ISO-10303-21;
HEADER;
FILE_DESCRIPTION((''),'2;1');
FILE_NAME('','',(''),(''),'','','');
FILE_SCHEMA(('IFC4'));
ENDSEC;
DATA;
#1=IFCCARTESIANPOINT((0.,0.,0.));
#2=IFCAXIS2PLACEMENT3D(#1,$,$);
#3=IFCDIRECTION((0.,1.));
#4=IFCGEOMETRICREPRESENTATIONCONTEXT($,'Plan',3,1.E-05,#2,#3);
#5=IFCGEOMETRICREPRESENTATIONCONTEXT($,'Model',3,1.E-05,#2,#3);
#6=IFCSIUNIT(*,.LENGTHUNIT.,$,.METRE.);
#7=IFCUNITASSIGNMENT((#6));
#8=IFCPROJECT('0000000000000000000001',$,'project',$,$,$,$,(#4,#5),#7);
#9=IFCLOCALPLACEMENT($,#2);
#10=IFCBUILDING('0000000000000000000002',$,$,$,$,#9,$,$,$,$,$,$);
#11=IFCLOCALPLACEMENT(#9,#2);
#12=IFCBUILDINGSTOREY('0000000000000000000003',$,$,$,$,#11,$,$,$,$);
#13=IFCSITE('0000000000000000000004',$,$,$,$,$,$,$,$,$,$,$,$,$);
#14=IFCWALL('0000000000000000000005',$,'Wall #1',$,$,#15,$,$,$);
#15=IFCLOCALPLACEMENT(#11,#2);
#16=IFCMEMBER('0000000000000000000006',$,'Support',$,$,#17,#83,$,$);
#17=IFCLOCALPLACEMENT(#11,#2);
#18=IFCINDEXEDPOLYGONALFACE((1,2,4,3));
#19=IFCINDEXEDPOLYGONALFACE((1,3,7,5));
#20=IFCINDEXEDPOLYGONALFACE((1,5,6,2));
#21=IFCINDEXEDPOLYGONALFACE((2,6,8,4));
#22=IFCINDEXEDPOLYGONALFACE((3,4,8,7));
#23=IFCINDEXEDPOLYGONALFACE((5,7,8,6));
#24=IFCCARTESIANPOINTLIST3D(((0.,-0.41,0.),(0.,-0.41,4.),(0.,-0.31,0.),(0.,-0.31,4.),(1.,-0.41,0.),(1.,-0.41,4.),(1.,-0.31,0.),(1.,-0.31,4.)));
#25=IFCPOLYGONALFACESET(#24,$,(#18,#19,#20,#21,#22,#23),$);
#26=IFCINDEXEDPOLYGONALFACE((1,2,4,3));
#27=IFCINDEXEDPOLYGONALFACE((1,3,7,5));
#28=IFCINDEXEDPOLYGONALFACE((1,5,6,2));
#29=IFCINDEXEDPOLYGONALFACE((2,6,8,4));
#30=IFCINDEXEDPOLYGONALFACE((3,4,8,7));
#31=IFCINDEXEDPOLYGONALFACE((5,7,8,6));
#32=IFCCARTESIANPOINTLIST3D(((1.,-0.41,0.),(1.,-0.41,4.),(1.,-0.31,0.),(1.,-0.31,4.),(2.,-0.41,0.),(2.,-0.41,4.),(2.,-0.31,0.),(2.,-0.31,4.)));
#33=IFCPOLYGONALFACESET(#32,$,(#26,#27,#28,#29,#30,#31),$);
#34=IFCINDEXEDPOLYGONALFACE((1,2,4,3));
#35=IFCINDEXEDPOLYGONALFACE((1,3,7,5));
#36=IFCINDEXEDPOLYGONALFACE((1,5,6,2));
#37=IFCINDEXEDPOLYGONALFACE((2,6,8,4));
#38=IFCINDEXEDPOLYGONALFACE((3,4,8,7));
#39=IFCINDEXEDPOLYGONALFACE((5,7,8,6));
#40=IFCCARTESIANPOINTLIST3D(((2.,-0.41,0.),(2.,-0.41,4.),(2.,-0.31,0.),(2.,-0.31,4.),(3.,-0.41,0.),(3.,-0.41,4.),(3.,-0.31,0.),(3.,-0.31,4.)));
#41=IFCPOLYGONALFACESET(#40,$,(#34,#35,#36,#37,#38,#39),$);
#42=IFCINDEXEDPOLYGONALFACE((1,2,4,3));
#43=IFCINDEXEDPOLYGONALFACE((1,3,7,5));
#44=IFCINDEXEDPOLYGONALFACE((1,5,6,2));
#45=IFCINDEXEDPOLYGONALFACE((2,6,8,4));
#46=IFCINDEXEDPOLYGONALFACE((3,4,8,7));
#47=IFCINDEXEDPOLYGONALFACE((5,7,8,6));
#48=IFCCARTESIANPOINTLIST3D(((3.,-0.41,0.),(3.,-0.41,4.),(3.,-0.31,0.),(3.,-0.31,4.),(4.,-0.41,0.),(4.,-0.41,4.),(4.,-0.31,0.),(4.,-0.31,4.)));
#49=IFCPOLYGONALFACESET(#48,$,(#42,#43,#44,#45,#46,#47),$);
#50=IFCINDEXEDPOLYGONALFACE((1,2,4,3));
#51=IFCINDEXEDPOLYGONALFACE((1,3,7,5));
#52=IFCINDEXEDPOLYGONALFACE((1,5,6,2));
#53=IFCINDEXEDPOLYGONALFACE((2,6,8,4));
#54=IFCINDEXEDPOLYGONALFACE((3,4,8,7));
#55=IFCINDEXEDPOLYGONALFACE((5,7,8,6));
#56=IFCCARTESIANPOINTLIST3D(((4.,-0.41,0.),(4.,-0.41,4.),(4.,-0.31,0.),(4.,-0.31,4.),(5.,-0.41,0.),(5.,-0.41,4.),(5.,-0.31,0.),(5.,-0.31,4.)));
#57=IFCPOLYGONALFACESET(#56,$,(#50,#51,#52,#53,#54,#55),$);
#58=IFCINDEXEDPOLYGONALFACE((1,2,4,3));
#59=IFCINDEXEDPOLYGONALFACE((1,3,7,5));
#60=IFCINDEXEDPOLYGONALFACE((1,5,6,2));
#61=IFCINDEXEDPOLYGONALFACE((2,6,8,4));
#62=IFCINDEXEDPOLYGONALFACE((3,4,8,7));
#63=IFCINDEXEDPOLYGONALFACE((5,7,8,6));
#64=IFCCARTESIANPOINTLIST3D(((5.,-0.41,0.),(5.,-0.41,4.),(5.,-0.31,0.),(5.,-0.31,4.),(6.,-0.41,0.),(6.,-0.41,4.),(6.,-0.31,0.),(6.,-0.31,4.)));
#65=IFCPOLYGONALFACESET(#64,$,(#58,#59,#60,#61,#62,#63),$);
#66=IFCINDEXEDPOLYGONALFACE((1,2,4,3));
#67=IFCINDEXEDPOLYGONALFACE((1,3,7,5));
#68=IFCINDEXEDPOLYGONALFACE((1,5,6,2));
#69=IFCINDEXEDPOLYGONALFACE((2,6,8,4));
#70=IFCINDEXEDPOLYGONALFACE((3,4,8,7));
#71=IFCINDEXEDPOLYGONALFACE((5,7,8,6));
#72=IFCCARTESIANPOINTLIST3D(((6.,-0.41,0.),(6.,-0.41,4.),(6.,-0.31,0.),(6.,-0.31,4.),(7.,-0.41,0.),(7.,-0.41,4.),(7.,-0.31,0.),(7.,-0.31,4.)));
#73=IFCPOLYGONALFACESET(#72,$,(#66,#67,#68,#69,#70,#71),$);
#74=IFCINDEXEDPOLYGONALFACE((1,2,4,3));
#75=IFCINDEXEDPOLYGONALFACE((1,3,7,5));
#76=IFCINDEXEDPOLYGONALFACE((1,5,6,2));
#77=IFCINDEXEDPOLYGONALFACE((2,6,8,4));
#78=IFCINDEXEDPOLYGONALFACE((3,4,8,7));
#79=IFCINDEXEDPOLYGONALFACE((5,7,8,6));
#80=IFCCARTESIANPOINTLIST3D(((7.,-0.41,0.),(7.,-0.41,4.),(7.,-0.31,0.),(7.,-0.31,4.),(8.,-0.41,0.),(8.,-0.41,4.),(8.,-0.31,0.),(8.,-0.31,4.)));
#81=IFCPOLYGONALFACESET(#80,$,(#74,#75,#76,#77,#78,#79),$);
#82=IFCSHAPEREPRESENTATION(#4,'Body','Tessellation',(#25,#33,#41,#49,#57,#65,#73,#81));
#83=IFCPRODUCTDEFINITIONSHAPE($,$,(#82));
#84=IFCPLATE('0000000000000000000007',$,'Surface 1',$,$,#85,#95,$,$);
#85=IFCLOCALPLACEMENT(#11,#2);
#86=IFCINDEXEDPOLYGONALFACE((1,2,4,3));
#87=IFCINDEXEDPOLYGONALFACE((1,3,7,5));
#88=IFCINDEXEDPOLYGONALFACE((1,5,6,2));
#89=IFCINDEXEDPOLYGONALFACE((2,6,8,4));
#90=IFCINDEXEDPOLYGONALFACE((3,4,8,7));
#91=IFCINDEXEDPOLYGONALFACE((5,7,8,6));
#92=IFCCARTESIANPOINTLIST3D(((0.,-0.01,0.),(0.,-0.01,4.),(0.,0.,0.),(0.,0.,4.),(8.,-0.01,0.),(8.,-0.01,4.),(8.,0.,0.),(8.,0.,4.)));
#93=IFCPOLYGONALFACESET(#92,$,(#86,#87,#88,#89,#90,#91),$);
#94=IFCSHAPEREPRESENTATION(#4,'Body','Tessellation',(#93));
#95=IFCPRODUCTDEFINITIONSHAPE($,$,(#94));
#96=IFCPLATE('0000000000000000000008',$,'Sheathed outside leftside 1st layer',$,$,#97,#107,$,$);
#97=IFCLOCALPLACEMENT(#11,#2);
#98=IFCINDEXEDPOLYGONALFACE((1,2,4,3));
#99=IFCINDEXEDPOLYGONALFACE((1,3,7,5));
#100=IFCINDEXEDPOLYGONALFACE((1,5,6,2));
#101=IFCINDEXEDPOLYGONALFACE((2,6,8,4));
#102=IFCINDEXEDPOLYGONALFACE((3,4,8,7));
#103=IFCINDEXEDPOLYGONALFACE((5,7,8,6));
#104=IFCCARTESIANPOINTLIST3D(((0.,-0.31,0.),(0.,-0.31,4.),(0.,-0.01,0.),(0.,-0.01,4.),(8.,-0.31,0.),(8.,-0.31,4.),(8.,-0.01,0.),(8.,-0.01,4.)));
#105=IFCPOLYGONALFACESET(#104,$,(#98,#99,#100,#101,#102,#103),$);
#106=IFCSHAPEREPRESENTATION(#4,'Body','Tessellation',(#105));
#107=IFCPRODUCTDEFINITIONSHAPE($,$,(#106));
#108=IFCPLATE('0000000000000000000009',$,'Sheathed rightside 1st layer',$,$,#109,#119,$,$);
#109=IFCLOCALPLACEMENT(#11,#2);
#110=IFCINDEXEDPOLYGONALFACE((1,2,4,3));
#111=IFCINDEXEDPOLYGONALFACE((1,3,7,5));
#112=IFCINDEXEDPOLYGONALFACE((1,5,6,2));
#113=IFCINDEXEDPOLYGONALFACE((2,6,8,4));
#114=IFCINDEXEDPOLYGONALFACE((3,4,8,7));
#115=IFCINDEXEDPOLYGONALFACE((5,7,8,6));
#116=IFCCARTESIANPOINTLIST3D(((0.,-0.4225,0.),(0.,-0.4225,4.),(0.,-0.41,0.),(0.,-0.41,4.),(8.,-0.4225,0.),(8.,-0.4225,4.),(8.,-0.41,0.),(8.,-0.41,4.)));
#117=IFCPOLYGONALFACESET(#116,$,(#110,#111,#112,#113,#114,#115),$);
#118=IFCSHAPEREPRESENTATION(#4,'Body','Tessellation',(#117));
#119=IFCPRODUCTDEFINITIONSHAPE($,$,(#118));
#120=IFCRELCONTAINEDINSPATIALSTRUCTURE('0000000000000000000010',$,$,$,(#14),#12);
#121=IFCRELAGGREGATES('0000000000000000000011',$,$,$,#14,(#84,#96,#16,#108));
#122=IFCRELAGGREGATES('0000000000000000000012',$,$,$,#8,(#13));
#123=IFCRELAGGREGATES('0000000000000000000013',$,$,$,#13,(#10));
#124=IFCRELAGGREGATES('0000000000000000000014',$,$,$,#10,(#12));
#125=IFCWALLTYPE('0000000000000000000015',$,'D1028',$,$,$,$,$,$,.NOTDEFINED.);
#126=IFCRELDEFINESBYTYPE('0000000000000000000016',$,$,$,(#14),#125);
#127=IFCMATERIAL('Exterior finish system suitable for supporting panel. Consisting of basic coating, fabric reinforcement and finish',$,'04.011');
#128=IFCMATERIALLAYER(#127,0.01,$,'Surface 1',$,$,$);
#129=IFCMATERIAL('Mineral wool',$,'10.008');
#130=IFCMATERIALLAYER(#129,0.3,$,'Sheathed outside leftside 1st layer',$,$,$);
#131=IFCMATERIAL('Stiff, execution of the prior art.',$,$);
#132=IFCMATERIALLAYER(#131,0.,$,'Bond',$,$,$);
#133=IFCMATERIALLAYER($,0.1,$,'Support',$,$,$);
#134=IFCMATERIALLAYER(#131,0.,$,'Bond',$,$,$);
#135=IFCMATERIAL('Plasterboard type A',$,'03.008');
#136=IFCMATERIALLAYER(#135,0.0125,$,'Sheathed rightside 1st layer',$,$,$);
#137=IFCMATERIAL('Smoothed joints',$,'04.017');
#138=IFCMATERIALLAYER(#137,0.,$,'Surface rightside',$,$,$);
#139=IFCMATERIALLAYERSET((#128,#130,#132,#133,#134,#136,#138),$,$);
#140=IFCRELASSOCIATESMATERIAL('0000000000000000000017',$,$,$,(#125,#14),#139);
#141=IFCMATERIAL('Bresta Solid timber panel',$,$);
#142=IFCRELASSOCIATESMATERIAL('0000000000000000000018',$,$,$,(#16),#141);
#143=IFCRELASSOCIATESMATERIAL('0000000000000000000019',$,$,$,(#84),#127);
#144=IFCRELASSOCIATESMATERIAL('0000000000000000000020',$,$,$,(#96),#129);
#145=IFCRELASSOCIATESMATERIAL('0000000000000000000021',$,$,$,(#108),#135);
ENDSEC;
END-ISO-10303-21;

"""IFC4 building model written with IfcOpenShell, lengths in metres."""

from ifc_helpers import new_model, si_unit, direction, frame, frame_2d, origin, origin_with_axes, place, context, project, spatial, rectangle, extrude, material, layer, layer_set, type_object, element, aggregate, save


model = new_model("IFC4")

# Units and contexts
plan_context = context("Plan", 3, precision=1e-05, world=origin(), true_north=direction((0.0, 1.0)))
model_context = context("Model", 3, precision=1e-05, world=origin(), true_north=direction((0.0, 1.0)))
ifc_project = project(units=[si_unit("LENGTHUNIT", "METRE")], contexts=[plan_context, model_context])

# Site, building, storey
site = spatial("IfcSite", under=ifc_project)
building_placement = place(None, origin())
building = spatial("IfcBuilding", under=site, at=building_placement)
storey_placement = place(building_placement, origin())
storey = spatial("IfcBuildingStorey", under=building, at=storey_placement)

# Wall, member, plates
ifc_material_1 = material(Name="Exterior finish system suitable for supporting panel. Consisting of basic coating, fabric reinforcement and finish", Category="04.011")
ifc_layer_1 = layer(ifc_material_1, 0.01, Name="Surface 1")
ifc_material_2 = material(Name="Mineral wool", Category="10.008")
ifc_layer_2 = layer(ifc_material_2, 0.3, Name="Sheathed outside leftside 1st layer")
ifc_material_3 = material(Name="Stiff, execution of the prior art.")
ifc_layer_3 = layer(ifc_material_3, 0.0, Name="Bond")
ifc_layer_4 = layer(None, 0.1, Name="Support")
ifc_layer_5 = layer(ifc_material_3, 0.0, Name="Bond")
ifc_material_4 = material(Name="Plasterboard type A", Category="03.008")
ifc_layer_6 = layer(ifc_material_4, 0.0125, Name="Sheathed rightside 1st layer")
ifc_material_5 = material(Name="Smoothed joints", Category="04.017")
ifc_layer_7 = layer(ifc_material_5, 0.0, Name="Surface rightside")
ifc_layer_set = layer_set([ifc_layer_1, ifc_layer_2, ifc_layer_3, ifc_layer_4, ifc_layer_5, ifc_layer_6, ifc_layer_7])
wall_type = type_object("IfcWallType", Name="D1028", PredefinedType="NOTDEFINED", material=ifc_layer_set)
wall_placement = place(None, frame((0.0, 0.0, 0.0), z_axis=(0.0, -1.0, 0.0), x_axis=(1.0, 0.0, 0.0)))
wall = element("IfcWall", 1, at=wall_placement, inside=storey, type_object=wall_type, material=ifc_layer_set, Name="Wall #1")
ifc_material_6 = material(Name="Bresta Solid timber panel")
member_placement = place(wall_placement, origin())
member = element("IfcMember", 2, at=member_placement, material=ifc_material_6, Name="Support", context=plan_context, shape_type="SweptSolid", body=[
    extrude(rectangle(XDim=1.0, YDim=0.1, at=frame_2d((0.5, 0.05), x_axis=(1.0, 0.0))), frame((0.0, 4.0, 0.31), z_axis=(0.0, -1.0, 0.0), x_axis=(1.0, 0.0, 0.0)), (0.0, 0.0, 1.0), 4.0),
    extrude(rectangle(XDim=1.0, YDim=0.1, at=frame_2d((0.5, 0.05), x_axis=(1.0, 0.0))), frame((1.0, 4.0, 0.31), z_axis=(0.0, -1.0, 0.0), x_axis=(1.0, 0.0, 0.0)), (0.0, 0.0, 1.0), 4.0),
    extrude(rectangle(XDim=1.0, YDim=0.1, at=frame_2d((0.5, 0.05), x_axis=(1.0, 0.0))), frame((2.0, 4.0, 0.31), z_axis=(0.0, -1.0, 0.0), x_axis=(1.0, 0.0, 0.0)), (0.0, 0.0, 1.0), 4.0),
    extrude(rectangle(XDim=1.0, YDim=0.1, at=frame_2d((0.5, 0.05), x_axis=(1.0, 0.0))), frame((3.0, 4.0, 0.31), z_axis=(0.0, -1.0, 0.0), x_axis=(1.0, 0.0, 0.0)), (0.0, 0.0, 1.0), 4.0),
    extrude(rectangle(XDim=1.0, YDim=0.1, at=frame_2d((0.5, 0.05), x_axis=(1.0, 0.0))), frame((4.0, 4.0, 0.31), z_axis=(0.0, -1.0, 0.0), x_axis=(1.0, 0.0, 0.0)), (0.0, 0.0, 1.0), 4.0),
    extrude(rectangle(XDim=1.0, YDim=0.1, at=frame_2d((0.5, 0.05), x_axis=(1.0, 0.0))), frame((5.0, 4.0, 0.31), z_axis=(0.0, -1.0, 0.0), x_axis=(1.0, 0.0, 0.0)), (0.0, 0.0, 1.0), 4.0),
    extrude(rectangle(XDim=1.0, YDim=0.1, at=frame_2d((0.5, 0.05), x_axis=(1.0, 0.0))), frame((6.0, 4.0, 0.31), z_axis=(0.0, -1.0, 0.0), x_axis=(1.0, 0.0, 0.0)), (0.0, 0.0, 1.0), 4.0),
    extrude(rectangle(XDim=1.0, YDim=0.1, at=frame_2d((0.5, 0.05), x_axis=(1.0, 0.0))), frame((7.0, 4.0, 0.31), z_axis=(0.0, -1.0, 0.0), x_axis=(1.0, 0.0, 0.0)), (0.0, 0.0, 1.0), 4.0),
])
plate_1_placement = place(wall_placement, origin())
plate_1 = element("IfcPlate", 3, at=plate_1_placement, material=ifc_material_1, Name="Surface 1", context=plan_context, shape_type="SweptSolid", body=[
    extrude(rectangle(XDim=8.0, YDim=4.0, at=frame_2d((4.0, 2.0), x_axis=(1.0, 0.0))), origin_with_axes(), (0.0, 0.0, 1.0), 0.01),
])
plate_2_placement = place(wall_placement, origin())
plate_2 = element("IfcPlate", 4, at=plate_2_placement, material=ifc_material_2, Name="Sheathed outside leftside 1st layer", context=plan_context, shape_type="SweptSolid", body=[
    extrude(rectangle(XDim=8.0, YDim=4.0, at=frame_2d((4.0, 2.0), x_axis=(1.0, 0.0))), frame((0.0, 0.0, 0.01), z_axis=(0.0, 0.0, 1.0), x_axis=(1.0, 0.0, 0.0)), (0.0, 0.0, 1.0), 0.3),
])
plate_3_placement = place(wall_placement, origin())
plate_3 = element("IfcPlate", 5, at=plate_3_placement, material=ifc_material_4, Name="Sheathed rightside 1st layer", context=plan_context, shape_type="SweptSolid", body=[
    extrude(rectangle(XDim=8.0, YDim=4.0, at=frame_2d((4.0, 2.0), x_axis=(1.0, 0.0))), frame((0.0, 0.0, 0.41), z_axis=(0.0, 0.0, 1.0), x_axis=(1.0, 0.0, 0.0)), (0.0, 0.0, 1.0), 0.0125),
])
aggregate(wall, [plate_1, plate_2, member, plate_3])

save(model, "model.ifc")
